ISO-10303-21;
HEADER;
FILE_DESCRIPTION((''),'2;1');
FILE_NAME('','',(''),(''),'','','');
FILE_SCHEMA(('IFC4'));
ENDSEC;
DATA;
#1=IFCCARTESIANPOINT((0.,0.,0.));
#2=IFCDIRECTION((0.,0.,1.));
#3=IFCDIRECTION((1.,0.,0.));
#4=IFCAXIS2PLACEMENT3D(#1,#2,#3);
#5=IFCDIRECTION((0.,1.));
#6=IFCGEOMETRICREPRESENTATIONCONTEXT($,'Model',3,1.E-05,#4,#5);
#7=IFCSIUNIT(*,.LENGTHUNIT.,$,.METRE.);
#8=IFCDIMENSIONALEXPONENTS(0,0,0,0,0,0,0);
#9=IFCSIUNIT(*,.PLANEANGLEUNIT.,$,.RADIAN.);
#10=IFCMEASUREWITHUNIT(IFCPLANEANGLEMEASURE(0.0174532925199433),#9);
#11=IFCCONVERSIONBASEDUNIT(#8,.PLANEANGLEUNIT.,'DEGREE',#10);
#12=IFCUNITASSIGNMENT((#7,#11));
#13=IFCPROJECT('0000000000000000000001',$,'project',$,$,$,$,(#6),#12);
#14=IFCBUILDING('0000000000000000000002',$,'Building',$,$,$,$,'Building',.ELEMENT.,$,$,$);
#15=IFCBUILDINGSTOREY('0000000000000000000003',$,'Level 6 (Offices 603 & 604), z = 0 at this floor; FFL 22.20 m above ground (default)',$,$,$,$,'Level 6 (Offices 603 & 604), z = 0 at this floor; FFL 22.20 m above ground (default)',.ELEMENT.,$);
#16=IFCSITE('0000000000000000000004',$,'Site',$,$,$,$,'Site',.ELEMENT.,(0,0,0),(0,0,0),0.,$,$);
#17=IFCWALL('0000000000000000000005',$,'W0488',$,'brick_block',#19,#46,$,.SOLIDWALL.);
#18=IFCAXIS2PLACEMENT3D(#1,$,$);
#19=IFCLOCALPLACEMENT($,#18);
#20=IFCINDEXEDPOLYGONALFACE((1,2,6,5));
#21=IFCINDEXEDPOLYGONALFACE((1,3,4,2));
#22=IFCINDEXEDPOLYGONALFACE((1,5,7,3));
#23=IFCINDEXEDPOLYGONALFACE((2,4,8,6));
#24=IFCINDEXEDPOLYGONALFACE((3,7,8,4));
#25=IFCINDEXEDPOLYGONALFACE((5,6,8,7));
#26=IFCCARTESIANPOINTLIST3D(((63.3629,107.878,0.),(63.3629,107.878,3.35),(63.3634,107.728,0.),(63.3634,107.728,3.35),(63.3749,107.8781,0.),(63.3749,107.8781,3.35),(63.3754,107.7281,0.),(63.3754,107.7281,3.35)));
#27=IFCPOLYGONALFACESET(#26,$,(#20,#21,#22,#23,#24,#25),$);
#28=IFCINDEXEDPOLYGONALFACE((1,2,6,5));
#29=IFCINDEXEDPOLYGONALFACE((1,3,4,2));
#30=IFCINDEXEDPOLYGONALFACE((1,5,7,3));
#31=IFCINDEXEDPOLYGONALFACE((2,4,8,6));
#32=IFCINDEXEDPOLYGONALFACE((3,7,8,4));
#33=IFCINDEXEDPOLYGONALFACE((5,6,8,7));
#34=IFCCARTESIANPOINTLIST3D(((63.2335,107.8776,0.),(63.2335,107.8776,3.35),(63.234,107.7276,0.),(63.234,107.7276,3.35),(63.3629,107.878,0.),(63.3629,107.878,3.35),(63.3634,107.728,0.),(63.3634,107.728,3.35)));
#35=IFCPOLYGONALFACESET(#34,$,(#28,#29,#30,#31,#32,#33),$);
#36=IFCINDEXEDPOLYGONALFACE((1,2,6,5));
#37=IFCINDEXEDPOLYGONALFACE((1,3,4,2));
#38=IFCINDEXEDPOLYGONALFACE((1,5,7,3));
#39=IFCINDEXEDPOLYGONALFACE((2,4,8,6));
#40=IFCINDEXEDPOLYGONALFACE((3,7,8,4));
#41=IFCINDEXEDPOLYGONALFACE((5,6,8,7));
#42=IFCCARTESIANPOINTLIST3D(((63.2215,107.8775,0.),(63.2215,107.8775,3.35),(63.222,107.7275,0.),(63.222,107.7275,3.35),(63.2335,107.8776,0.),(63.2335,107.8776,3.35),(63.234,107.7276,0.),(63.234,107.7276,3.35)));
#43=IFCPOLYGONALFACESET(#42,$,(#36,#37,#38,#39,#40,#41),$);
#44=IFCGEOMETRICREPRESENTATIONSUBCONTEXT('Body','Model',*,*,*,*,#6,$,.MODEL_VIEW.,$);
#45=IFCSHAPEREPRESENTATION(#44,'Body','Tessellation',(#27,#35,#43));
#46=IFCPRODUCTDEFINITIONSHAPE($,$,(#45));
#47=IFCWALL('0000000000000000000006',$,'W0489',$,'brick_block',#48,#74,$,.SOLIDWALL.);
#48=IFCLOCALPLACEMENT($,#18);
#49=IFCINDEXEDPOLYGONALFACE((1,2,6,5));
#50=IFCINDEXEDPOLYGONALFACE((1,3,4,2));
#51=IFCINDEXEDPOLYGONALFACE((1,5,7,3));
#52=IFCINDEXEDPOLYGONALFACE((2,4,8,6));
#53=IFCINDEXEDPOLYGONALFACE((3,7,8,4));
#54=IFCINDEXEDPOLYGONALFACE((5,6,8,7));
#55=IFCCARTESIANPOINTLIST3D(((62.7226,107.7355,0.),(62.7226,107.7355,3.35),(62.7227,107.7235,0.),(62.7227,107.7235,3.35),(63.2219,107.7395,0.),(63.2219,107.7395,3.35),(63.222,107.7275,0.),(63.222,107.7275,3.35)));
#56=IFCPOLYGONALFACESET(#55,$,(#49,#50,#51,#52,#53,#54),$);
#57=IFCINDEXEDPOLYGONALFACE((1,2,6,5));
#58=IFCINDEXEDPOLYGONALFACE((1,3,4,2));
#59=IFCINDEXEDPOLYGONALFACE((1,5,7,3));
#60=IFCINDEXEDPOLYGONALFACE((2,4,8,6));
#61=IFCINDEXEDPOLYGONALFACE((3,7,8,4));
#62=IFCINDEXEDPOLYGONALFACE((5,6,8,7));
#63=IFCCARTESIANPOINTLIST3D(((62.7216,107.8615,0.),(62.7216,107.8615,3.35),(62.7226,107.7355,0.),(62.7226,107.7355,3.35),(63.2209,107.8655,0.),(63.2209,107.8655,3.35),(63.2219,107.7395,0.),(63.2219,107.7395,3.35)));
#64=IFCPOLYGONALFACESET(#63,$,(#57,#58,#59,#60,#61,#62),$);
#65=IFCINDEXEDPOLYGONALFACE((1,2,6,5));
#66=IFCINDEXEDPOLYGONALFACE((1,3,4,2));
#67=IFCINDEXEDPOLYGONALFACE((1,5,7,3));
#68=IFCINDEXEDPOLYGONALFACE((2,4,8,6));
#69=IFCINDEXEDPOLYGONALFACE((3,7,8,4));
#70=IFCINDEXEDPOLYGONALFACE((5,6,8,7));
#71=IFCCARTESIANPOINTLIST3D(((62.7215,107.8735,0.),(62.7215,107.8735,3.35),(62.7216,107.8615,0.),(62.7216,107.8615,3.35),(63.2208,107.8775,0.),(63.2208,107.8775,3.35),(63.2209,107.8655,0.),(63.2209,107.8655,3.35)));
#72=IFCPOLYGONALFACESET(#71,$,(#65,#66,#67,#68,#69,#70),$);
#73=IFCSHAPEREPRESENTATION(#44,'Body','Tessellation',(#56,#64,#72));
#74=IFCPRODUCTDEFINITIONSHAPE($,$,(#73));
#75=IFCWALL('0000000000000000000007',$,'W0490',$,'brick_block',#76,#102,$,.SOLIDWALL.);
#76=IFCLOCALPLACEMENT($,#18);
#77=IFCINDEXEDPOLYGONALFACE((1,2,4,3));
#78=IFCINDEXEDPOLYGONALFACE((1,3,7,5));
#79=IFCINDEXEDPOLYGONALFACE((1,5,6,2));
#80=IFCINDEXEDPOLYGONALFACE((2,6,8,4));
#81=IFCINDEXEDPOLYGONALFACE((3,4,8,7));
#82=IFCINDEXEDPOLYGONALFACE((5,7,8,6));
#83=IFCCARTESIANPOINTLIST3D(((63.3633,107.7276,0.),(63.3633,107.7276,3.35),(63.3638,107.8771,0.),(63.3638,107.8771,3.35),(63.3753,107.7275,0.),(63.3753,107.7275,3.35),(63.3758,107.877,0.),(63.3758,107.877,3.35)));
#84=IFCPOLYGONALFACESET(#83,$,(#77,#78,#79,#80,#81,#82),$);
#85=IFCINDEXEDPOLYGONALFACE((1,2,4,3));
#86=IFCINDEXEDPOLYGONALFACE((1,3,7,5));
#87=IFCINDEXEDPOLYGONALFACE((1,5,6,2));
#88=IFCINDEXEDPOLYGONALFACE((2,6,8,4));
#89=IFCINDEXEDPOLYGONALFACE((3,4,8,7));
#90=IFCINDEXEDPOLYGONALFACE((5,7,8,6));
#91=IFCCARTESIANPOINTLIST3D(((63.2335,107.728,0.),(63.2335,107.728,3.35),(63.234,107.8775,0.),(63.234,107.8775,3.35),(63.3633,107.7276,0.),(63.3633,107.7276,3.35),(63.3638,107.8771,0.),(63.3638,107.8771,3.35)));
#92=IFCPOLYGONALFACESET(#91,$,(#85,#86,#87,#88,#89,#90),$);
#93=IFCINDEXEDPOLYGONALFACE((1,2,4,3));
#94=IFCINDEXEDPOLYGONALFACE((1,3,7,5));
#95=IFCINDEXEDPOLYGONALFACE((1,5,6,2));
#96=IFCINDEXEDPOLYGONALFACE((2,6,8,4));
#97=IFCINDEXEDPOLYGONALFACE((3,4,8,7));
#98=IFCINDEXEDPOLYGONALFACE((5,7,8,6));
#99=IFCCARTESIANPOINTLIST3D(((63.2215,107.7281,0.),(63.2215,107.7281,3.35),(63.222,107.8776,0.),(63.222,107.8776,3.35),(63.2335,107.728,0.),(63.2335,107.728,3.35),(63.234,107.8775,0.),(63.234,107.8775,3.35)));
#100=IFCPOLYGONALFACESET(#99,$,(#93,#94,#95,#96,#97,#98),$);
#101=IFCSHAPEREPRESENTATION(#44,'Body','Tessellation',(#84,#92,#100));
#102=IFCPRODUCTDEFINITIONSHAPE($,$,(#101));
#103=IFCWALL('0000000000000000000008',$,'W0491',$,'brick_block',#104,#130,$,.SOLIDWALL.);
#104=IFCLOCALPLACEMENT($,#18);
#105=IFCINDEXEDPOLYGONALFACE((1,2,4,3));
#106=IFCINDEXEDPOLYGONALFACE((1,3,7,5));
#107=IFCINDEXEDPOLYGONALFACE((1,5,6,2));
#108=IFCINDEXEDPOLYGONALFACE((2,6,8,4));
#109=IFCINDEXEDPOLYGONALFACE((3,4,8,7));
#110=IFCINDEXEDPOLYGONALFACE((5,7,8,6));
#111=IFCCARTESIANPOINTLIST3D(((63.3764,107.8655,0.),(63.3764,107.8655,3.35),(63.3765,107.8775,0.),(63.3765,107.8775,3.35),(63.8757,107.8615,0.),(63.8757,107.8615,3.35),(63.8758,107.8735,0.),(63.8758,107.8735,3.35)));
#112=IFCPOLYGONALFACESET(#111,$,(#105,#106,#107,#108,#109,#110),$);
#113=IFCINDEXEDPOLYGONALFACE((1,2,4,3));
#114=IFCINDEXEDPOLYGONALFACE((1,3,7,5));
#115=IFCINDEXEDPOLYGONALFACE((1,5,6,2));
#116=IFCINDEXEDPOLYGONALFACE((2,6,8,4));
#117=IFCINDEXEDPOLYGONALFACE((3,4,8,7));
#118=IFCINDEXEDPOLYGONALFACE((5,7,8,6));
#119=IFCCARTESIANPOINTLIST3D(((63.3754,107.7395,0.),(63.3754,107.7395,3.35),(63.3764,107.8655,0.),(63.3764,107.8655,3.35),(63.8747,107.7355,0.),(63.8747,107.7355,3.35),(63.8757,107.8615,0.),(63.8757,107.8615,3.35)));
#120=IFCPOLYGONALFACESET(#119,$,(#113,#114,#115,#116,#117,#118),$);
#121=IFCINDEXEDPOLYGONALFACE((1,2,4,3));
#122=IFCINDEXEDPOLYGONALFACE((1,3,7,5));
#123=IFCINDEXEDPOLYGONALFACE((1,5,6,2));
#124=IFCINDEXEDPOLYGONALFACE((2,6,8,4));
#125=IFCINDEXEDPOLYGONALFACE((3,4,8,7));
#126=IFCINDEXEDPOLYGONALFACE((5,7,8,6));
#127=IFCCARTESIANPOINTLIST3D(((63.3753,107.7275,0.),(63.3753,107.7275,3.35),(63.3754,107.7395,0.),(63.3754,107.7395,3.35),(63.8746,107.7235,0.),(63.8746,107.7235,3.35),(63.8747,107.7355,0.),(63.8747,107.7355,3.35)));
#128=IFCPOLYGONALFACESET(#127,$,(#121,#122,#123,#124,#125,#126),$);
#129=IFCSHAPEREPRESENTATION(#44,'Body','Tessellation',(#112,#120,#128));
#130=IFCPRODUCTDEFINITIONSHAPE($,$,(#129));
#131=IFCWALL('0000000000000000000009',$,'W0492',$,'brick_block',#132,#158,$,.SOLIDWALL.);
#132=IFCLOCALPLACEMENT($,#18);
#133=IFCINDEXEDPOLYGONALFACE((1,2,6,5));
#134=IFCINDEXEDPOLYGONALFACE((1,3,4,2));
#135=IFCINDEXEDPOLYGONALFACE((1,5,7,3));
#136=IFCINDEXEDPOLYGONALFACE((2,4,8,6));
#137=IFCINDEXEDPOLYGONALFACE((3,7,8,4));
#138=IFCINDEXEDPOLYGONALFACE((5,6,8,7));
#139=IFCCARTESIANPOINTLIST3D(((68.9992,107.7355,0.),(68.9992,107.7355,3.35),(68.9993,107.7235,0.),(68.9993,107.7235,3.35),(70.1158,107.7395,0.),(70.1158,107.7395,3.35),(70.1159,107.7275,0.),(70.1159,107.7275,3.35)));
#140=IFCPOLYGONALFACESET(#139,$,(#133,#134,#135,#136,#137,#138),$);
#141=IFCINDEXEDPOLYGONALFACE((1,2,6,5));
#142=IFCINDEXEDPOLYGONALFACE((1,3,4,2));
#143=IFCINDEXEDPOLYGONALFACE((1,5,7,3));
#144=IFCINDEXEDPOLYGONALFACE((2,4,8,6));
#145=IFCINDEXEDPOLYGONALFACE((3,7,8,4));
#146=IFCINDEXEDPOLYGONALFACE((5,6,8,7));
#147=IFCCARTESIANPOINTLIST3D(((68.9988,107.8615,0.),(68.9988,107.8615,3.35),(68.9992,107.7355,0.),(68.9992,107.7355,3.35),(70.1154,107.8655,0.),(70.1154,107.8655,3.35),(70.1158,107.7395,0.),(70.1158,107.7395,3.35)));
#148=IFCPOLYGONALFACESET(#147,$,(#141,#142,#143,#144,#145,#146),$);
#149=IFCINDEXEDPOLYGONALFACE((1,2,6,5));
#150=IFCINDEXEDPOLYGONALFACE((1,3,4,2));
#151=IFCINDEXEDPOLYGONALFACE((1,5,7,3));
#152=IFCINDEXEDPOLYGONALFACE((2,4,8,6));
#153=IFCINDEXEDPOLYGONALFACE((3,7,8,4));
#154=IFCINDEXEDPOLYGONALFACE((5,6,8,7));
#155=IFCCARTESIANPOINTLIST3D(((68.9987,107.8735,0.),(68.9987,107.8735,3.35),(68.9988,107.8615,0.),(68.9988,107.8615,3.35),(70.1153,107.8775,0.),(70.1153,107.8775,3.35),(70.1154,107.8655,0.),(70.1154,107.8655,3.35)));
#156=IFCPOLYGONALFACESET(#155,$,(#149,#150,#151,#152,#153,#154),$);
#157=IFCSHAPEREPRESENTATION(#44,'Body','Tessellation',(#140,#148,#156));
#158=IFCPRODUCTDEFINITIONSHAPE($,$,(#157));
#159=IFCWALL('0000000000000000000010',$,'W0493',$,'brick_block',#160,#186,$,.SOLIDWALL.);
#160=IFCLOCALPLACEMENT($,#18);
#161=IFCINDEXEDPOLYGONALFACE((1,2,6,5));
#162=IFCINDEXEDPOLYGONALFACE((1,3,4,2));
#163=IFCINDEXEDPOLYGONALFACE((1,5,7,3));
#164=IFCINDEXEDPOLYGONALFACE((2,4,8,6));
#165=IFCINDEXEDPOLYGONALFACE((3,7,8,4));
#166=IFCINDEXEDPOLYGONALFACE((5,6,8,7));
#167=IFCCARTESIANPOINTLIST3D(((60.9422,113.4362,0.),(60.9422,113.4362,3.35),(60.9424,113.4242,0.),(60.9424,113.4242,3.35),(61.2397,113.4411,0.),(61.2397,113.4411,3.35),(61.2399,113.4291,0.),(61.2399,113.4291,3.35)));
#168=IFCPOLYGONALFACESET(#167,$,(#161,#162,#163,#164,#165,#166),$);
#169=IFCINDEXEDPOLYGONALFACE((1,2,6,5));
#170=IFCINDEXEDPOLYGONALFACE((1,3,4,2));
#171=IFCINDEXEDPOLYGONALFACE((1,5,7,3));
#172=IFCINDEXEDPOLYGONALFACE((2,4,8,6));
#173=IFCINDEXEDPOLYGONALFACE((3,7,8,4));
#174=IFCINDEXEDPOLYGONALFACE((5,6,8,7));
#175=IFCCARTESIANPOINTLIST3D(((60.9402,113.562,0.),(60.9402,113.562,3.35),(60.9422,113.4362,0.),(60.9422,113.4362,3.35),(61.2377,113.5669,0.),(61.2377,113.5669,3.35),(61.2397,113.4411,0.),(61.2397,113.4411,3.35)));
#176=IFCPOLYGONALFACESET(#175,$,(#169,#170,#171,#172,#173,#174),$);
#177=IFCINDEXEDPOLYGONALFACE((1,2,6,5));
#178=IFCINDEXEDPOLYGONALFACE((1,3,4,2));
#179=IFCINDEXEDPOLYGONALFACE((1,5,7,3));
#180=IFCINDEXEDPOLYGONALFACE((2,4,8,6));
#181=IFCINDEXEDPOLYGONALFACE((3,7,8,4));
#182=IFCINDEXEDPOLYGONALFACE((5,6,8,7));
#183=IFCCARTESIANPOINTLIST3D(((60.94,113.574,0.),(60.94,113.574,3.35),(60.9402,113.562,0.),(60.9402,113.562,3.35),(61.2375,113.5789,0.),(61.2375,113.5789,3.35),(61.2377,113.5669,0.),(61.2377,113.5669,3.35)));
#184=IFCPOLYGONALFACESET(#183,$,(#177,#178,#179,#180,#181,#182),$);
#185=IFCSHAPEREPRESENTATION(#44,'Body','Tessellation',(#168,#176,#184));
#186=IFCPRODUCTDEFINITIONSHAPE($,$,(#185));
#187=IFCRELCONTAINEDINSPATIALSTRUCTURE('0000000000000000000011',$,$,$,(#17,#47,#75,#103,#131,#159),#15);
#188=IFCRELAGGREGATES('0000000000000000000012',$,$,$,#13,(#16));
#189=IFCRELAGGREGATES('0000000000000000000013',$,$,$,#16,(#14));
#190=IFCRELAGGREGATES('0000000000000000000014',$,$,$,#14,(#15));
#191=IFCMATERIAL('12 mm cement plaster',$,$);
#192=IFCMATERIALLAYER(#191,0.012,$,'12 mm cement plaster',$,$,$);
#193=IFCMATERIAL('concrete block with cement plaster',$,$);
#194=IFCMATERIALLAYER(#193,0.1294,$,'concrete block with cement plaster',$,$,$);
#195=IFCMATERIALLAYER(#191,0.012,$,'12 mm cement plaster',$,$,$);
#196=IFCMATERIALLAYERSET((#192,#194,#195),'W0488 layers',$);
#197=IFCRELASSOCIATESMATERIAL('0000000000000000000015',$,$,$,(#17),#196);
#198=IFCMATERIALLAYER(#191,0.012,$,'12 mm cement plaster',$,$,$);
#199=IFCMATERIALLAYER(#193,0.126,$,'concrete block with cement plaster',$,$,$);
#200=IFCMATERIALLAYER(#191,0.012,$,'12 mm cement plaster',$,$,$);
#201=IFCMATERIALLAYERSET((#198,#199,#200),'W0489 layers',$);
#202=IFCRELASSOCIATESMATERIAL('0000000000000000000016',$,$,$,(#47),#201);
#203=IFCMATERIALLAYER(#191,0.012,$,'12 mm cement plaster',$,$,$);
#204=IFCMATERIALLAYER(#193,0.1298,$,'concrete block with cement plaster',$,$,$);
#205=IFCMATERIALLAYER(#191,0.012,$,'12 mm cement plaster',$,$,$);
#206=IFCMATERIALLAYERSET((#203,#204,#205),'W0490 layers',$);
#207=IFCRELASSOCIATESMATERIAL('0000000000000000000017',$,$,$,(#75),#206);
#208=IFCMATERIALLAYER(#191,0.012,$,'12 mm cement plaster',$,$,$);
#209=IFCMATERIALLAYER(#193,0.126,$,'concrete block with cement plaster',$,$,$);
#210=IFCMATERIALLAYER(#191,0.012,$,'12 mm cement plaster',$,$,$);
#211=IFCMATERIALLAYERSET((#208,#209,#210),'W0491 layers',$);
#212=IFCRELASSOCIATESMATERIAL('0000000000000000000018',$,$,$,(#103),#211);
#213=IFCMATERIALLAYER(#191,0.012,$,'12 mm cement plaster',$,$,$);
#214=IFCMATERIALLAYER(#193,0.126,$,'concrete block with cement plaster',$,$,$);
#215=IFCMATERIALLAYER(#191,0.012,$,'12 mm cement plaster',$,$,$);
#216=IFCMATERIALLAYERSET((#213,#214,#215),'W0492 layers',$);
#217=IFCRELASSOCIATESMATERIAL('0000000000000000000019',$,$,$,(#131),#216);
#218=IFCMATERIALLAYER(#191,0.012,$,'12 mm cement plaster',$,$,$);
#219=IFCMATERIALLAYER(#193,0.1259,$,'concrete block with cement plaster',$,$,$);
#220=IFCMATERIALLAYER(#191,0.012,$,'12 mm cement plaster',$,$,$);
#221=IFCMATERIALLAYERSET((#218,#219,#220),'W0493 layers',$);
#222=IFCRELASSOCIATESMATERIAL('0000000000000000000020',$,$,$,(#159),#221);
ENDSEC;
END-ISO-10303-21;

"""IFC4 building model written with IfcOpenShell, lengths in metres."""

from ifc_helpers import new_model, entity, si_unit, converted_unit, direction, frame, frame_2d, origin_with_axes, place, context, subcontext, project, spatial, rectangle, extrude, material, layer, layer_set, layer_usage, element, save


model = new_model("IFC4")

# Units and contexts
model_context = context("Model", 3, precision=1e-05, world=origin_with_axes(), true_north=direction((0.0, 1.0)))
body_context = subcontext(model_context, "Body", "Model", "MODEL_VIEW")
ifc_project = project(units=[si_unit("LENGTHUNIT", "METRE"), converted_unit("PLANEANGLEUNIT", "DEGREE", entity("IfcPlaneAngleMeasure", 0.0174532925199433), si_unit("PLANEANGLEUNIT", "RADIAN"), dimensions=[0, 0, 0, 0, 0, 0, 0])], contexts=[model_context])

# Site, building, storey
site = spatial("IfcSite", under=ifc_project, Name="Site", LongName="Site", CompositionType="ELEMENT", RefLatitude=(0, 0, 0), RefLongitude=(0, 0, 0), RefElevation=0.0)
building = spatial("IfcBuilding", under=site, Name="Building", LongName="Building", CompositionType="ELEMENT")
storey = spatial("IfcBuildingStorey", under=building, Name="Level 6 (Offices 603 & 604), z = 0 at this floor; FFL 22.20 m above ground (default)", LongName="Level 6 (Offices 603 & 604), z = 0 at this floor; FFL 22.20 m above ground (default)", CompositionType="ELEMENT")

# Walls
placement = place(None, origin_with_axes())
ifc_material_1 = material(Name="12 mm cement plaster")
ifc_material_2 = material(Name="concrete block with cement plaster")
ifc_layer_1 = layer(ifc_material_1, 0.012, Name="12 mm cement plaster")
ifc_layer_2 = layer(ifc_material_2, 0.1294, Name="concrete block with cement plaster")
ifc_layer_3 = layer(ifc_material_1, 0.012, Name="12 mm cement plaster")
ifc_layer_set_1 = layer_set([ifc_layer_1, ifc_layer_2, ifc_layer_3], Name="W0488 layers")
ifc_layer_usage_1 = layer_usage(ifc_layer_set_1, "AXIS2", "POSITIVE", -0.0767)
element("IfcWall", 1, at=placement, inside=storey, material=ifc_layer_usage_1, Name="W0488", ObjectType="brick_block", PredefinedType="SOLIDWALL", context=body_context, shape_type="SweptSolid", body=[
    extrude(rectangle(XDim=0.15, YDim=0.012, at=frame_2d((0.0, 0.0), x_axis=(0.003333, -0.999994))), frame((63.3691, 107.803, 0.0), z_axis=(0.0, 0.0, 1.0), x_axis=(1.0, 0.0, 0.0)), (0.0, 0.0, 1.0), 3.35),
    extrude(rectangle(XDim=0.15, YDim=0.1294, at=frame_2d((-0.0707, -0.0002), x_axis=(0.003333, -0.999994))), frame((63.3691, 107.803, 0.0), z_axis=(0.0, 0.0, 1.0), x_axis=(1.0, 0.0, 0.0)), (0.0, 0.0, 1.0), 3.35),
    extrude(rectangle(XDim=0.15, YDim=0.012, at=frame_2d((-0.1414, -0.0005), x_axis=(0.003333, -0.999994))), frame((63.3691, 107.803, 0.0), z_axis=(0.0, 0.0, 1.0), x_axis=(1.0, 0.0, 0.0)), (0.0, 0.0, 1.0), 3.35),
])
ifc_layer_4 = layer(ifc_material_1, 0.012, Name="12 mm cement plaster")
ifc_layer_5 = layer(ifc_material_2, 0.126, Name="concrete block with cement plaster")
ifc_layer_6 = layer(ifc_material_1, 0.012, Name="12 mm cement plaster")
ifc_layer_set_2 = layer_set([ifc_layer_4, ifc_layer_5, ifc_layer_6], Name="W0489 layers")
ifc_layer_usage_2 = layer_usage(ifc_layer_set_2, "AXIS2", "POSITIVE", -0.075)
element("IfcWall", 2, at=placement, inside=storey, material=ifc_layer_usage_2, Name="W0489", ObjectType="brick_block", PredefinedType="SOLIDWALL", context=body_context, shape_type="SweptSolid", body=[
    extrude(rectangle(XDim=0.4993, YDim=0.012, at=frame_2d((0.0, 0.0), x_axis=(0.999968, 0.008011))), frame((62.9723, 107.7315, 0.0), z_axis=(0.0, 0.0, 1.0), x_axis=(1.0, 0.0, 0.0)), (0.0, 0.0, 1.0), 3.35),
    extrude(rectangle(XDim=0.4993, YDim=0.126, at=frame_2d((-0.0006, 0.069), x_axis=(0.999968, 0.008011))), frame((62.9723, 107.7315, 0.0), z_axis=(0.0, 0.0, 1.0), x_axis=(1.0, 0.0, 0.0)), (0.0, 0.0, 1.0), 3.35),
    extrude(rectangle(XDim=0.4993, YDim=0.012, at=frame_2d((-0.0011, 0.138), x_axis=(0.999968, 0.008011))), frame((62.9723, 107.7315, 0.0), z_axis=(0.0, 0.0, 1.0), x_axis=(1.0, 0.0, 0.0)), (0.0, 0.0, 1.0), 3.35),
])
ifc_layer_7 = layer(ifc_material_1, 0.012, Name="12 mm cement plaster")
ifc_layer_8 = layer(ifc_material_2, 0.1298, Name="concrete block with cement plaster")
ifc_layer_9 = layer(ifc_material_1, 0.012, Name="12 mm cement plaster")
ifc_layer_set_3 = layer_set([ifc_layer_7, ifc_layer_8, ifc_layer_9], Name="W0490 layers")
ifc_layer_usage_3 = layer_usage(ifc_layer_set_3, "AXIS2", "POSITIVE", -0.0769)
element("IfcWall", 3, at=placement, inside=storey, material=ifc_layer_usage_3, Name="W0490", ObjectType="brick_block", PredefinedType="SOLIDWALL", context=body_context, shape_type="SweptSolid", body=[
    extrude(rectangle(XDim=0.1495, YDim=0.012, at=frame_2d((0.0, 0.0), x_axis=(0.003344, 0.999994))), frame((63.3695, 107.8023, 0.0), z_axis=(0.0, 0.0, 1.0), x_axis=(1.0, 0.0, 0.0)), (0.0, 0.0, 1.0), 3.35),
    extrude(rectangle(XDim=0.1495, YDim=0.1298, at=frame_2d((-0.0709, 0.0002), x_axis=(0.003344, 0.999994))), frame((63.3695, 107.8023, 0.0), z_axis=(0.0, 0.0, 1.0), x_axis=(1.0, 0.0, 0.0)), (0.0, 0.0, 1.0), 3.35),
    extrude(rectangle(XDim=0.1495, YDim=0.012, at=frame_2d((-0.1418, 0.0005), x_axis=(0.003344, 0.999994))), frame((63.3695, 107.8023, 0.0), z_axis=(0.0, 0.0, 1.0), x_axis=(1.0, 0.0, 0.0)), (0.0, 0.0, 1.0), 3.35),
])
ifc_layer_10 = layer(ifc_material_1, 0.012, Name="12 mm cement plaster")
ifc_layer_11 = layer(ifc_material_2, 0.126, Name="concrete block with cement plaster")
ifc_layer_12 = layer(ifc_material_1, 0.012, Name="12 mm cement plaster")
ifc_layer_set_4 = layer_set([ifc_layer_10, ifc_layer_11, ifc_layer_12], Name="W0491 layers")
ifc_layer_usage_4 = layer_usage(ifc_layer_set_4, "AXIS2", "POSITIVE", -0.075)
element("IfcWall", 4, at=placement, inside=storey, material=ifc_layer_usage_4, Name="W0491", ObjectType="brick_block", PredefinedType="SOLIDWALL", context=body_context, shape_type="SweptSolid", body=[
    extrude(rectangle(XDim=0.4993, YDim=0.012, at=frame_2d((0.0, 0.0), x_axis=(0.999968, -0.008011))), frame((63.6261, 107.8695, 0.0), z_axis=(0.0, 0.0, 1.0), x_axis=(1.0, 0.0, 0.0)), (0.0, 0.0, 1.0), 3.35),
    extrude(rectangle(XDim=0.4993, YDim=0.126, at=frame_2d((-0.0006, -0.069), x_axis=(0.999968, -0.008011))), frame((63.6261, 107.8695, 0.0), z_axis=(0.0, 0.0, 1.0), x_axis=(1.0, 0.0, 0.0)), (0.0, 0.0, 1.0), 3.35),
    extrude(rectangle(XDim=0.4993, YDim=0.012, at=frame_2d((-0.0011, -0.138), x_axis=(0.999968, -0.008011))), frame((63.6261, 107.8695, 0.0), z_axis=(0.0, 0.0, 1.0), x_axis=(1.0, 0.0, 0.0)), (0.0, 0.0, 1.0), 3.35),
])
ifc_layer_13 = layer(ifc_material_1, 0.012, Name="12 mm cement plaster")
ifc_layer_14 = layer(ifc_material_2, 0.126, Name="concrete block with cement plaster")
ifc_layer_15 = layer(ifc_material_1, 0.012, Name="12 mm cement plaster")
ifc_layer_set_5 = layer_set([ifc_layer_13, ifc_layer_14, ifc_layer_15], Name="W0492 layers")
ifc_layer_usage_5 = layer_usage(ifc_layer_set_5, "AXIS2", "POSITIVE", -0.075)
element("IfcWall", 5, at=placement, inside=storey, material=ifc_layer_usage_5, Name="W0492", ObjectType="brick_block", PredefinedType="SOLIDWALL", context=body_context, shape_type="SweptSolid", body=[
    extrude(rectangle(XDim=1.1166, YDim=0.012, at=frame_2d((0.0, 0.0), x_axis=(0.999994, 0.003582))), frame((69.5575, 107.7315, 0.0), z_axis=(0.0, 0.0, 1.0), x_axis=(1.0, 0.0, 0.0)), (0.0, 0.0, 1.0), 3.35),
    extrude(rectangle(XDim=1.1166, YDim=0.126, at=frame_2d((-0.0002, 0.069), x_axis=(0.999994, 0.003582))), frame((69.5575, 107.7315, 0.0), z_axis=(0.0, 0.0, 1.0), x_axis=(1.0, 0.0, 0.0)), (0.0, 0.0, 1.0), 3.35),
    extrude(rectangle(XDim=1.1166, YDim=0.012, at=frame_2d((-0.0005, 0.138), x_axis=(0.999994, 0.003582))), frame((69.5575, 107.7315, 0.0), z_axis=(0.0, 0.0, 1.0), x_axis=(1.0, 0.0, 0.0)), (0.0, 0.0, 1.0), 3.35),
])
ifc_layer_16 = layer(ifc_material_1, 0.012, Name="12 mm cement plaster")
ifc_layer_17 = layer(ifc_material_2, 0.1259, Name="concrete block with cement plaster")
ifc_layer_18 = layer(ifc_material_1, 0.012, Name="12 mm cement plaster")
ifc_layer_set_6 = layer_set([ifc_layer_16, ifc_layer_17, ifc_layer_18], Name="W0493 layers")
ifc_layer_usage_6 = layer_usage(ifc_layer_set_6, "AXIS2", "POSITIVE", -0.075)
element("IfcWall", 6, at=placement, inside=storey, material=ifc_layer_usage_6, Name="W0493", ObjectType="brick_block", PredefinedType="SOLIDWALL", context=body_context, shape_type="SweptSolid", body=[
    extrude(rectangle(XDim=0.2975, YDim=0.012, at=frame_2d((0.0, 0.0), x_axis=(0.999864, 0.016468))), frame((61.0911, 113.4326, 0.0), z_axis=(0.0, 0.0, 1.0), x_axis=(1.0, 0.0, 0.0)), (0.0, 0.0, 1.0), 3.35),
    extrude(rectangle(XDim=0.2975, YDim=0.1259, at=frame_2d((-0.0011, 0.0689), x_axis=(0.999864, 0.016468))), frame((61.0911, 113.4326, 0.0), z_axis=(0.0, 0.0, 1.0), x_axis=(1.0, 0.0, 0.0)), (0.0, 0.0, 1.0), 3.35),
    extrude(rectangle(XDim=0.2975, YDim=0.012, at=frame_2d((-0.0023, 0.1379), x_axis=(0.999864, 0.016468))), frame((61.0911, 113.4326, 0.0), z_axis=(0.0, 0.0, 1.0), x_axis=(1.0, 0.0, 0.0)), (0.0, 0.0, 1.0), 3.35),
])

save(model, "model.ifc")
